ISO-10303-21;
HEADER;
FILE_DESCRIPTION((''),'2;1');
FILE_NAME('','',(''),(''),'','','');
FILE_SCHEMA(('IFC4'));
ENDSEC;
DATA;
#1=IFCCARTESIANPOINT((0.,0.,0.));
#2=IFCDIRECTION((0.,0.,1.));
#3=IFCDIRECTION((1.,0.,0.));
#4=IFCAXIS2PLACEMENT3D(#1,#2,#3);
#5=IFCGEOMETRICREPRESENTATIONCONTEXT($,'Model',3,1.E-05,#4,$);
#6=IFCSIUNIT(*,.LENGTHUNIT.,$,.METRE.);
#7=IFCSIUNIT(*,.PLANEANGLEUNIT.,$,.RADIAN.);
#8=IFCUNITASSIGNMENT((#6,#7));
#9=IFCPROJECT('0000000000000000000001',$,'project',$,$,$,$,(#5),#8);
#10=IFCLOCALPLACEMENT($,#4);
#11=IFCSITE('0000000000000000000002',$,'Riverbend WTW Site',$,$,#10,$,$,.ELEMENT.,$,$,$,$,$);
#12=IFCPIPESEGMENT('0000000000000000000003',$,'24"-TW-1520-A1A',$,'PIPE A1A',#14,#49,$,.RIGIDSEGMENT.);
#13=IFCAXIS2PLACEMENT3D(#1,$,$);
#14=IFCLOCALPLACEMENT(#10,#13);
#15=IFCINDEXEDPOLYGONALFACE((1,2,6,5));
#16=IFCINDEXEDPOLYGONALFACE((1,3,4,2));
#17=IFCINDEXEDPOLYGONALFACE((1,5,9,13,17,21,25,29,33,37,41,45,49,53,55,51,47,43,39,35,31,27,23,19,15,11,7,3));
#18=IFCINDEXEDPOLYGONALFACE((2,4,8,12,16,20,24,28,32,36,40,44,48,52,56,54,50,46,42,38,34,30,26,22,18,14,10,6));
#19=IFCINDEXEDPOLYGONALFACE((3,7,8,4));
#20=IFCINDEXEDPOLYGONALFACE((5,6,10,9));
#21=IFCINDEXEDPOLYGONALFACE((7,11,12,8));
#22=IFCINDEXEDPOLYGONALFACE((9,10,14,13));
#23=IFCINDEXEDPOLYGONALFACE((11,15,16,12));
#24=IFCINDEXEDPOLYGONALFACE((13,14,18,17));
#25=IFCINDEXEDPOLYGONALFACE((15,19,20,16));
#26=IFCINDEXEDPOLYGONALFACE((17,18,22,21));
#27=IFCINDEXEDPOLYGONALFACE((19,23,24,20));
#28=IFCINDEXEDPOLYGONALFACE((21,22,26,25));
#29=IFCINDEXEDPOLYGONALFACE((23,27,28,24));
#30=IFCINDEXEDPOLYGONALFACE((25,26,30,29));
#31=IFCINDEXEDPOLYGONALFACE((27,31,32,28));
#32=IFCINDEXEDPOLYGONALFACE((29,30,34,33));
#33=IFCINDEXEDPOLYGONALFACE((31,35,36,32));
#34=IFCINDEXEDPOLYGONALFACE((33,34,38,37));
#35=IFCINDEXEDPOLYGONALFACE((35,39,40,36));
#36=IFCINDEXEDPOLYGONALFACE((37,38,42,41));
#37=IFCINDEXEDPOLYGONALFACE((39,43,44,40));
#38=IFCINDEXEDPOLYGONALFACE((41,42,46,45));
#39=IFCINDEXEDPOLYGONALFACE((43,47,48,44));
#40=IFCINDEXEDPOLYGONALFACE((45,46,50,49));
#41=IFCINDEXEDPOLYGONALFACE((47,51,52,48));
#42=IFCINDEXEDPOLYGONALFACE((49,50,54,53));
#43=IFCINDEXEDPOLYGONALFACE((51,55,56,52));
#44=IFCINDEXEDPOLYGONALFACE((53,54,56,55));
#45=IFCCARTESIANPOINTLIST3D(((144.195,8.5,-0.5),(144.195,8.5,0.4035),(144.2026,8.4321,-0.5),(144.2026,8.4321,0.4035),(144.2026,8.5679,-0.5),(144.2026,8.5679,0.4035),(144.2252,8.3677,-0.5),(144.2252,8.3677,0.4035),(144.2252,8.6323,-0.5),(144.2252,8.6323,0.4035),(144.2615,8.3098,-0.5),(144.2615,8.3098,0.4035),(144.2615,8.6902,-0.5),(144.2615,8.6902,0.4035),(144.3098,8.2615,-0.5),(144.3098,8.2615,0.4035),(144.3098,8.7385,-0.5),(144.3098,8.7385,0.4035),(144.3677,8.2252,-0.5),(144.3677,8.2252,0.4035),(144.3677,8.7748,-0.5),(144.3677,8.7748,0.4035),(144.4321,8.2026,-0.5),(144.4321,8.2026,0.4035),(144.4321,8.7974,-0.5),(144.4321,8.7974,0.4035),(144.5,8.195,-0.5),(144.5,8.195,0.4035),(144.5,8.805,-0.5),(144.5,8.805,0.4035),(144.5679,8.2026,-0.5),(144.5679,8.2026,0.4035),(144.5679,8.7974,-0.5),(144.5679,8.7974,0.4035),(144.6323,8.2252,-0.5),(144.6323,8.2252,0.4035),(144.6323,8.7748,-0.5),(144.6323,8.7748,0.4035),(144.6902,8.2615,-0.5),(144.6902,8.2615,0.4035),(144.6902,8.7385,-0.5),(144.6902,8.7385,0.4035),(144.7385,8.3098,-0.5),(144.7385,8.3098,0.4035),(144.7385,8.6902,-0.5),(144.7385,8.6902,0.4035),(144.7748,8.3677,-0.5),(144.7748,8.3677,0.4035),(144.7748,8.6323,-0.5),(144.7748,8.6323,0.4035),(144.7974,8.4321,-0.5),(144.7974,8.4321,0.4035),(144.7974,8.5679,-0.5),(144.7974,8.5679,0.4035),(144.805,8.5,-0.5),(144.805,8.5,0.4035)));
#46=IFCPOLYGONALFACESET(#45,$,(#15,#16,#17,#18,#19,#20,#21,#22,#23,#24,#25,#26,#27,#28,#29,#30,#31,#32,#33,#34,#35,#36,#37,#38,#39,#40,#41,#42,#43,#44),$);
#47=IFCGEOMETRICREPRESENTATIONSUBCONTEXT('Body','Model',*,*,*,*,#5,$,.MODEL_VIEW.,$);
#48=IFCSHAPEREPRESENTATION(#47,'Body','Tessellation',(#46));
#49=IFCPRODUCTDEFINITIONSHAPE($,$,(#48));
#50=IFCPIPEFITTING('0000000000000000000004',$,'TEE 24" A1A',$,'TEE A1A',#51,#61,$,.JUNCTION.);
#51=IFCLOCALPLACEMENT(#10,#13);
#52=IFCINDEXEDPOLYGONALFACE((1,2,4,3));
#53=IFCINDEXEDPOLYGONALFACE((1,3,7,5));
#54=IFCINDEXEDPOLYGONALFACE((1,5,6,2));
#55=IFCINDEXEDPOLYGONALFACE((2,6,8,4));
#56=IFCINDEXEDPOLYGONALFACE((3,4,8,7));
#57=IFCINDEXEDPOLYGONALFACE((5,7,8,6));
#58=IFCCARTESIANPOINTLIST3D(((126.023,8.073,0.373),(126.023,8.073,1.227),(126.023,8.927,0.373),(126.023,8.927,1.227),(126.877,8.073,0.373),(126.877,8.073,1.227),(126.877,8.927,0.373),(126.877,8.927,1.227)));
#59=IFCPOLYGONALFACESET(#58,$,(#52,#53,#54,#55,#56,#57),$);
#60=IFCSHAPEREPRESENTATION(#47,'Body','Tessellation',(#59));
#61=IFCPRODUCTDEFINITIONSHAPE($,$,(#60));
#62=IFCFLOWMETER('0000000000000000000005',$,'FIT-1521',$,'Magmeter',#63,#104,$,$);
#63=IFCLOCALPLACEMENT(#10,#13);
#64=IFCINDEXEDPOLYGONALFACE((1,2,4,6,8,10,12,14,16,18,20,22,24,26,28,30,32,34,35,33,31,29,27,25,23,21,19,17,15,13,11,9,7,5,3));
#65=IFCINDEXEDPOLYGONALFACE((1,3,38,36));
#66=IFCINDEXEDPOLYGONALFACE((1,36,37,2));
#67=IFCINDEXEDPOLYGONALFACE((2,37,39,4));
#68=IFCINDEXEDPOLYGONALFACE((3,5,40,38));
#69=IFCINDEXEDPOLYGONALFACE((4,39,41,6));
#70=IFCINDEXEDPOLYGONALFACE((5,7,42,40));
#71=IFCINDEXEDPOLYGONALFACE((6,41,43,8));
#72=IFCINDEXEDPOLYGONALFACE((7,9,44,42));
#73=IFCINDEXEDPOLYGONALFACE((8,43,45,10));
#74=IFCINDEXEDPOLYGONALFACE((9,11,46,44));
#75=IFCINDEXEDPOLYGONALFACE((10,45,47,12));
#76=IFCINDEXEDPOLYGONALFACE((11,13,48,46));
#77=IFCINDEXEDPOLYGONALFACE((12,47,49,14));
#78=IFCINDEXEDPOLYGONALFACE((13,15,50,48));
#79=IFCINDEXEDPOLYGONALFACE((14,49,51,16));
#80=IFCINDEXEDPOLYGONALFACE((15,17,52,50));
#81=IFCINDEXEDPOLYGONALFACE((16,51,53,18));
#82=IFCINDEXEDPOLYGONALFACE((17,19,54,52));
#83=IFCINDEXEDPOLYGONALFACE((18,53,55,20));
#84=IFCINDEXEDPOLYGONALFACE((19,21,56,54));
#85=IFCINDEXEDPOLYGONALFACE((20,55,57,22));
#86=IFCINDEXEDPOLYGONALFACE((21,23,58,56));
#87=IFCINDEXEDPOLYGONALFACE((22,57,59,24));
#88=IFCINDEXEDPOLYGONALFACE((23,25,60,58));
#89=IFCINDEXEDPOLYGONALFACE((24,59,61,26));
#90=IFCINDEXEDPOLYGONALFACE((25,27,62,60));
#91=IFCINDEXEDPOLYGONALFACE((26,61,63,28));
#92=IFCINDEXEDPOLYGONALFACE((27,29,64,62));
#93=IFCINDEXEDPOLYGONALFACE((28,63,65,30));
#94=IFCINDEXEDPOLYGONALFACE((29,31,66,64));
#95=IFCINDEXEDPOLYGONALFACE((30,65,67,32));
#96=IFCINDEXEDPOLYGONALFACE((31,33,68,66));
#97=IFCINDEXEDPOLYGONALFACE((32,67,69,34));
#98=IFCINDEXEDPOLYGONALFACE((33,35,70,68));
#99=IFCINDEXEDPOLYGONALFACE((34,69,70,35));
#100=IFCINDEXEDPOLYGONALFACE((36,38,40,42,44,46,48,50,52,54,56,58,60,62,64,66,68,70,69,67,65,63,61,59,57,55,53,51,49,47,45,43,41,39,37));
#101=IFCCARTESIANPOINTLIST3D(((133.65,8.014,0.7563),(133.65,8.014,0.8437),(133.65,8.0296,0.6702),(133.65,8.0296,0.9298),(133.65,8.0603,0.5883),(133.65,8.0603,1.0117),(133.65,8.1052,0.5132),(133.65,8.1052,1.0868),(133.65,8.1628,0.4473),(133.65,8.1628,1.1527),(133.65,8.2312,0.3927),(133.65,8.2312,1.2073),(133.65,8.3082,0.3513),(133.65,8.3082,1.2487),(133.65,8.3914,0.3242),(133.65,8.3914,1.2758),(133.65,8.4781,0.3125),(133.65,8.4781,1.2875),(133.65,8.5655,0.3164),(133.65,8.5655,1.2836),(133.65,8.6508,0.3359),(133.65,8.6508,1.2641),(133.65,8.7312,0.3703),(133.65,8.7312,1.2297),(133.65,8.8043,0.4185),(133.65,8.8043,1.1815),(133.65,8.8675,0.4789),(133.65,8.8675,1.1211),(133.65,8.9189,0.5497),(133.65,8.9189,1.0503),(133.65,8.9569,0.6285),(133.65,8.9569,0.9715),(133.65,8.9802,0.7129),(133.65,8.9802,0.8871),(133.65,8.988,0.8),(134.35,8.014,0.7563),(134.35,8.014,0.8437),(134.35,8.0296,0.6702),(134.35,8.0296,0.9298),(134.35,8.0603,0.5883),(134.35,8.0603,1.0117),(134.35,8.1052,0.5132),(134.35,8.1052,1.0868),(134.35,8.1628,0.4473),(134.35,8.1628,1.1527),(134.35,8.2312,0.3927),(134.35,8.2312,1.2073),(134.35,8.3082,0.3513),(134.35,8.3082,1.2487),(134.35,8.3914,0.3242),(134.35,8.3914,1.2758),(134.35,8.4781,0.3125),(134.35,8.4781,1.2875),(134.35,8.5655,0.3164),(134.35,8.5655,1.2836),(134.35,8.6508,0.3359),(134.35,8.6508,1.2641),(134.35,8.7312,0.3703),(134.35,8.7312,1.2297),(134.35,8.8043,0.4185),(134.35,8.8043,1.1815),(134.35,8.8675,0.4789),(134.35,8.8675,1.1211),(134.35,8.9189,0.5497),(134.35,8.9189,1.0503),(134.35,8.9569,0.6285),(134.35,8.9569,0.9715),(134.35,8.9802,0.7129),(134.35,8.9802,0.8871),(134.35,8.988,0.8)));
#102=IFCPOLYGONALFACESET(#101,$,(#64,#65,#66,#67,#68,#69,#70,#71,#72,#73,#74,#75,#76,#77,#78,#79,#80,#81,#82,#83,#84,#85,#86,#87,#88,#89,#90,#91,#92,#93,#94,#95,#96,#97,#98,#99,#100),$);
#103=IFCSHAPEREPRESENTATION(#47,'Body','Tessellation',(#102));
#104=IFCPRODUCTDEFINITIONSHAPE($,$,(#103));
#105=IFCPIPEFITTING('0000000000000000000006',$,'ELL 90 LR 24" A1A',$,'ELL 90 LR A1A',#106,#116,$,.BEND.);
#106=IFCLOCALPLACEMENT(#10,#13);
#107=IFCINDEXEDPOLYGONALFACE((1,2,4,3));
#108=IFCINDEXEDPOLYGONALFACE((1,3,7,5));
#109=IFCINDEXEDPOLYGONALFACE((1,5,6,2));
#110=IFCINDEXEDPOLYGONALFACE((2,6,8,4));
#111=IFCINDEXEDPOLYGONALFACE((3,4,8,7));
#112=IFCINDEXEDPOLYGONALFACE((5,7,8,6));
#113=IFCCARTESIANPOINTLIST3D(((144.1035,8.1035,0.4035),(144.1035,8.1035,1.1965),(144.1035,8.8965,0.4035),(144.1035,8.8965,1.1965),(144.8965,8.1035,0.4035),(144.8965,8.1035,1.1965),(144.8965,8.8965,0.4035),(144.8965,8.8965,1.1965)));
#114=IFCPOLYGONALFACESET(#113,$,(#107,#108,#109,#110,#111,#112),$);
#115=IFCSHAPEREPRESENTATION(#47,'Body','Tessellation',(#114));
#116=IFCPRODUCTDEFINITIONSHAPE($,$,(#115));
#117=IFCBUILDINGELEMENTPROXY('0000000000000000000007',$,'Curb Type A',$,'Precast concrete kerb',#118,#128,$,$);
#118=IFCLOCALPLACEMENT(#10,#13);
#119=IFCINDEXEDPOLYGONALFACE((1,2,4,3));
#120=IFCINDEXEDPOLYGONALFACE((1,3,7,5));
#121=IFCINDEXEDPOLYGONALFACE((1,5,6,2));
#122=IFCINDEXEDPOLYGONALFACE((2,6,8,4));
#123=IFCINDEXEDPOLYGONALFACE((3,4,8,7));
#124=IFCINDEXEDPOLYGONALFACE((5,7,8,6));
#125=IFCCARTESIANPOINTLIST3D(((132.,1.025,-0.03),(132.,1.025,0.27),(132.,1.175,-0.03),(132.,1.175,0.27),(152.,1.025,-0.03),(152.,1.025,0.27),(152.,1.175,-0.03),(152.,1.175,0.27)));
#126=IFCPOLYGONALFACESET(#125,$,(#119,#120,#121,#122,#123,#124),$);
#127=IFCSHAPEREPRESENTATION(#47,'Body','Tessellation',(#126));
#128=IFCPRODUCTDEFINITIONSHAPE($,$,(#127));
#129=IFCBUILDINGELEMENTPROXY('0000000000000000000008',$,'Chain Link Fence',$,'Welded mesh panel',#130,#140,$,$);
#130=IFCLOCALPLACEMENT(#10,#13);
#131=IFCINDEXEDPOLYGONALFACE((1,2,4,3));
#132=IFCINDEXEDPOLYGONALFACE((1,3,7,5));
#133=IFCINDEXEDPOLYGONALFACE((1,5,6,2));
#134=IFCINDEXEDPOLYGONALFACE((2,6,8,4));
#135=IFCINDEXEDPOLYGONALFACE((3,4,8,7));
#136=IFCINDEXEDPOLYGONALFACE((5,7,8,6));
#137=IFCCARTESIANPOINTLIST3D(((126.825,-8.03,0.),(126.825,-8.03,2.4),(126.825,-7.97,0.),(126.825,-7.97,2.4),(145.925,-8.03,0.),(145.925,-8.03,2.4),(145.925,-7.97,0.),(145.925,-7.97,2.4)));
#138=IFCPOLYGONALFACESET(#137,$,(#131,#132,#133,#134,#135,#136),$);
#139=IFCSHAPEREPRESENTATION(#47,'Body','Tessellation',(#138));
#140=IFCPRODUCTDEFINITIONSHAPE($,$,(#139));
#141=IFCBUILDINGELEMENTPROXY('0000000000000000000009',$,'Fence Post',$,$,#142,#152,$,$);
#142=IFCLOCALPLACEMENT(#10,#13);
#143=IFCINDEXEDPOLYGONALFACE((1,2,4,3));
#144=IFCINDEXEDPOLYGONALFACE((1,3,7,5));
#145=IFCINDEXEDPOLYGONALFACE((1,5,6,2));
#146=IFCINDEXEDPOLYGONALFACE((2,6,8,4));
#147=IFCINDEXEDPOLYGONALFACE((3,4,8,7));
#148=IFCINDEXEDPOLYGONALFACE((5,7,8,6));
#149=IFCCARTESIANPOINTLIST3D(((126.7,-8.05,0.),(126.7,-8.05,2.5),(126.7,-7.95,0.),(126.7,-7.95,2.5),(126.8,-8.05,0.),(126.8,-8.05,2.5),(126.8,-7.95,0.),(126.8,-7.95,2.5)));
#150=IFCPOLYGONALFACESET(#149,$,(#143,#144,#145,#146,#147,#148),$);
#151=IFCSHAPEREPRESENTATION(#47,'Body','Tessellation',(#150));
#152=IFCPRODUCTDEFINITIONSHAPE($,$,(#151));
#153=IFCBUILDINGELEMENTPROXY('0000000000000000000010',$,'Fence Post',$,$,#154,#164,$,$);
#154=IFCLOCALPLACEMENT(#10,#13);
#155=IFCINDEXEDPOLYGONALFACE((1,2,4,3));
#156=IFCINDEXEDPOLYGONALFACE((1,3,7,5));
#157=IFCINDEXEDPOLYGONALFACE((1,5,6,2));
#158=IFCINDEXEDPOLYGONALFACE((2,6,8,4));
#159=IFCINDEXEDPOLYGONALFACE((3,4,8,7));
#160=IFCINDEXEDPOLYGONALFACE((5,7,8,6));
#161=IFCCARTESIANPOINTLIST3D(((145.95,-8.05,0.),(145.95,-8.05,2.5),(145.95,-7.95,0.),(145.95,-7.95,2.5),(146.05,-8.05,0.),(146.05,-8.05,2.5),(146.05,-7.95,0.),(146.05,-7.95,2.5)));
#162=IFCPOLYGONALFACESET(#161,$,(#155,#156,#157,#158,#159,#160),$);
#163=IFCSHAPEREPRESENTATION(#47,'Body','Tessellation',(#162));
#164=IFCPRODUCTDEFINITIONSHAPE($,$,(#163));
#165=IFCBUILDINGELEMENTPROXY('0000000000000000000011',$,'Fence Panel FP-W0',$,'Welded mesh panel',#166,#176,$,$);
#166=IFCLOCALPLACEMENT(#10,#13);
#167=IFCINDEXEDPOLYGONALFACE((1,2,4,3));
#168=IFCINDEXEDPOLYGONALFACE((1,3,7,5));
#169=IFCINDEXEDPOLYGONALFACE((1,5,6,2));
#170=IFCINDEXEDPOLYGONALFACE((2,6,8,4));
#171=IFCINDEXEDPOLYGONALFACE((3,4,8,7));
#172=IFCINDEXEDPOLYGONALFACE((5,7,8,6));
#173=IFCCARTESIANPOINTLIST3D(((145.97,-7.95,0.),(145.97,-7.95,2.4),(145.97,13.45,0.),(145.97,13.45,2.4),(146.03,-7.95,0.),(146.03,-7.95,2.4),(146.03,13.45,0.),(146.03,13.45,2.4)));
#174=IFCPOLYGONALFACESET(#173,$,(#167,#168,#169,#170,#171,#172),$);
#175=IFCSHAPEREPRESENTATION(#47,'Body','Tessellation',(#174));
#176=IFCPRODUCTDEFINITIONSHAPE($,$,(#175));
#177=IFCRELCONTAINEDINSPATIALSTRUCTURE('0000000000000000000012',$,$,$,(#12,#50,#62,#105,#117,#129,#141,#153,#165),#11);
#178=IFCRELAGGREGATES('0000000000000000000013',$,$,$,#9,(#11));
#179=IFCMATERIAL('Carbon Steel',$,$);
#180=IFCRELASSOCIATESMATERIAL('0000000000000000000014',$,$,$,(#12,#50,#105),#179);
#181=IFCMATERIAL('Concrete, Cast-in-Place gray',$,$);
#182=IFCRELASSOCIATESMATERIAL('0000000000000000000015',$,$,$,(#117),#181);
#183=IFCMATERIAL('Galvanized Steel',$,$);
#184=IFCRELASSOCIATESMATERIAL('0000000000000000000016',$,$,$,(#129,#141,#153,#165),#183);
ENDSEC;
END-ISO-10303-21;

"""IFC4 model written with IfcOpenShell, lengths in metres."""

from ifc_helpers import new_model, si_unit, frame, origin_with_axes, origin_2d, place, context, subcontext, project, spatial, rectangle, circle, extrude, material, element, save


model = new_model("IFC4")

# Units and contexts
model_context = context("Model", 3, precision=1e-05, world=origin_with_axes())
body_context = subcontext(model_context, "Body", "Model", "MODEL_VIEW")
ifc_project = project(units=[si_unit("LENGTHUNIT", "METRE"), si_unit("PLANEANGLEUNIT", "RADIAN")], contexts=[model_context])

# Site
site_placement = place(None, origin_with_axes())
site = spatial("IfcSite", under=ifc_project, at=site_placement, Name="Riverbend WTW Site", CompositionType="ELEMENT")

# Pipe segment
ifc_material_1 = material(Name="Carbon Steel")
pipe_segment_1_placement = place(None, frame((144.5, 8.5, 0.4035), z_axis=(0.0, 0.0, 1.0), x_axis=(1.0, 0.0, 0.0)))
element("IfcPipeSegment", 1, at=pipe_segment_1_placement, inside=site, material=ifc_material_1, Name="24\"-TW-1520-A1A", ObjectType="PIPE A1A", PredefinedType="RIGIDSEGMENT", context=body_context, shape_type="SweptSolid", body=[
    extrude(circle(Radius=0.305, at=origin_2d()), frame((0.0, 0.0, 0.0), z_axis=(0.0, 0.0, -1.0), x_axis=(1.0, 0.0, 0.0)), (0.0, 0.0, 1.0), 0.9035),
])

# Pipe fitting
pipe_fitting_1_placement = place(None, frame((126.45, 8.5, 0.8), z_axis=(0.0, 0.0, 1.0), x_axis=(1.0, 0.0, 0.0)))
element("IfcPipeFitting", 2, at=pipe_fitting_1_placement, inside=site, material=ifc_material_1, Name="TEE 24\" A1A", ObjectType="TEE A1A", PredefinedType="JUNCTION", context=body_context, shape_type="SweptSolid", body=[
    extrude(rectangle(XDim=0.854, YDim=0.854, at=origin_2d()), frame((0.0, 0.0, -0.427), z_axis=(0.0, 0.0, 1.0), x_axis=(1.0, 0.0, 0.0)), (0.0, 0.0, 1.0), 0.854),
])

# Flow meter
flow_meter_placement = place(None, frame((133.65, 8.5, 0.8), z_axis=(0.0, 0.0, 1.0), x_axis=(1.0, 0.0, 0.0)))
element("IfcFlowMeter", 3, at=flow_meter_placement, inside=site, Name="FIT-1521", ObjectType="Magmeter", context=body_context, shape_type="SweptSolid", body=[
    extrude(circle(Radius=0.488, at=origin_2d()), frame((0.0, 0.0, 0.0), z_axis=(1.0, 0.0, 0.0), x_axis=(0.0, 1.0, 0.0)), (0.0, 0.0, 1.0), 0.7),
])

# Pipe fitting
pipe_fitting_2_placement = place(None, frame((144.5, 8.5, 0.8), z_axis=(0.0, 0.0, 1.0), x_axis=(1.0, 0.0, 0.0)))
element("IfcPipeFitting", 4, at=pipe_fitting_2_placement, inside=site, material=ifc_material_1, Name="ELL 90 LR 24\" A1A", ObjectType="ELL 90 LR A1A", PredefinedType="BEND", context=body_context, shape_type="SweptSolid", body=[
    extrude(rectangle(XDim=0.793, YDim=0.793, at=origin_2d()), frame((0.0, 0.0, -0.3965), z_axis=(0.0, 0.0, 1.0), x_axis=(1.0, 0.0, 0.0)), (0.0, 0.0, 1.0), 0.793),
])

# Building element proxies
ifc_material_2 = material(Name="Concrete, Cast-in-Place gray")
proxy_1_placement = place(None, frame((142.0, 1.1, 0.12), z_axis=(0.0, 0.0, 1.0), x_axis=(1.0, 0.0, 0.0)))
element("IfcBuildingElementProxy", 5, at=proxy_1_placement, inside=site, material=ifc_material_2, Name="Curb Type A", ObjectType="Precast concrete kerb", context=body_context, shape_type="SweptSolid", body=[
    extrude(rectangle(XDim=20.0, YDim=0.15, at=origin_2d()), frame((0.0, 0.0, -0.15), z_axis=(0.0, 0.0, 1.0), x_axis=(1.0, 0.0, 0.0)), (0.0, 0.0, 1.0), 0.3),
])
ifc_material_3 = material(Name="Galvanized Steel")
proxy_2_placement = place(None, frame((136.375, -8.0, 1.2), z_axis=(0.0, 0.0, 1.0), x_axis=(1.0, 0.0, 0.0)))
element("IfcBuildingElementProxy", 6, at=proxy_2_placement, inside=site, material=ifc_material_3, Name="Chain Link Fence", ObjectType="Welded mesh panel", context=body_context, shape_type="SweptSolid", body=[
    extrude(rectangle(XDim=19.1, YDim=0.06, at=origin_2d()), frame((0.0, 0.0, -1.2), z_axis=(0.0, 0.0, 1.0), x_axis=(1.0, 0.0, 0.0)), (0.0, 0.0, 1.0), 2.4),
])
for number, where, z_axis, x_axis, name in (
    (7, (126.75, -8.0, 1.25), (0.0, 0.0, 1.0), (1.0, 0.0, 0.0), "Fence Post"),
    (8, (146.0, -8.0, 1.25), (0.0, 0.0, 1.0), (1.0, 0.0, 0.0), "Fence Post"),
):
    element("IfcBuildingElementProxy", number, at=place(None, frame(where, z_axis=z_axis, x_axis=x_axis)), inside=site, material=ifc_material_3, Name=name, context=body_context, shape_type="SweptSolid", body=[
        extrude(rectangle(XDim=0.1, YDim=0.1, at=origin_2d()), frame((0.0, 0.0, -1.25), z_axis=(0.0, 0.0, 1.0), x_axis=(1.0, 0.0, 0.0)), (0.0, 0.0, 1.0), 2.5),
    ])
proxy_3_placement = place(None, frame((146.0, 2.75, 1.2), z_axis=(0.0, 0.0, 1.0), x_axis=(1.0, 0.0, 0.0)))
element("IfcBuildingElementProxy", 9, at=proxy_3_placement, inside=site, material=ifc_material_3, Name="Fence Panel FP-W0", ObjectType="Welded mesh panel", context=body_context, shape_type="SweptSolid", body=[
    extrude(rectangle(XDim=0.06, YDim=21.4, at=origin_2d()), frame((0.0, 0.0, -1.2), z_axis=(0.0, 0.0, 1.0), x_axis=(1.0, 0.0, 0.0)), (0.0, 0.0, 1.0), 2.4),
])

save(model, "model.ifc")
